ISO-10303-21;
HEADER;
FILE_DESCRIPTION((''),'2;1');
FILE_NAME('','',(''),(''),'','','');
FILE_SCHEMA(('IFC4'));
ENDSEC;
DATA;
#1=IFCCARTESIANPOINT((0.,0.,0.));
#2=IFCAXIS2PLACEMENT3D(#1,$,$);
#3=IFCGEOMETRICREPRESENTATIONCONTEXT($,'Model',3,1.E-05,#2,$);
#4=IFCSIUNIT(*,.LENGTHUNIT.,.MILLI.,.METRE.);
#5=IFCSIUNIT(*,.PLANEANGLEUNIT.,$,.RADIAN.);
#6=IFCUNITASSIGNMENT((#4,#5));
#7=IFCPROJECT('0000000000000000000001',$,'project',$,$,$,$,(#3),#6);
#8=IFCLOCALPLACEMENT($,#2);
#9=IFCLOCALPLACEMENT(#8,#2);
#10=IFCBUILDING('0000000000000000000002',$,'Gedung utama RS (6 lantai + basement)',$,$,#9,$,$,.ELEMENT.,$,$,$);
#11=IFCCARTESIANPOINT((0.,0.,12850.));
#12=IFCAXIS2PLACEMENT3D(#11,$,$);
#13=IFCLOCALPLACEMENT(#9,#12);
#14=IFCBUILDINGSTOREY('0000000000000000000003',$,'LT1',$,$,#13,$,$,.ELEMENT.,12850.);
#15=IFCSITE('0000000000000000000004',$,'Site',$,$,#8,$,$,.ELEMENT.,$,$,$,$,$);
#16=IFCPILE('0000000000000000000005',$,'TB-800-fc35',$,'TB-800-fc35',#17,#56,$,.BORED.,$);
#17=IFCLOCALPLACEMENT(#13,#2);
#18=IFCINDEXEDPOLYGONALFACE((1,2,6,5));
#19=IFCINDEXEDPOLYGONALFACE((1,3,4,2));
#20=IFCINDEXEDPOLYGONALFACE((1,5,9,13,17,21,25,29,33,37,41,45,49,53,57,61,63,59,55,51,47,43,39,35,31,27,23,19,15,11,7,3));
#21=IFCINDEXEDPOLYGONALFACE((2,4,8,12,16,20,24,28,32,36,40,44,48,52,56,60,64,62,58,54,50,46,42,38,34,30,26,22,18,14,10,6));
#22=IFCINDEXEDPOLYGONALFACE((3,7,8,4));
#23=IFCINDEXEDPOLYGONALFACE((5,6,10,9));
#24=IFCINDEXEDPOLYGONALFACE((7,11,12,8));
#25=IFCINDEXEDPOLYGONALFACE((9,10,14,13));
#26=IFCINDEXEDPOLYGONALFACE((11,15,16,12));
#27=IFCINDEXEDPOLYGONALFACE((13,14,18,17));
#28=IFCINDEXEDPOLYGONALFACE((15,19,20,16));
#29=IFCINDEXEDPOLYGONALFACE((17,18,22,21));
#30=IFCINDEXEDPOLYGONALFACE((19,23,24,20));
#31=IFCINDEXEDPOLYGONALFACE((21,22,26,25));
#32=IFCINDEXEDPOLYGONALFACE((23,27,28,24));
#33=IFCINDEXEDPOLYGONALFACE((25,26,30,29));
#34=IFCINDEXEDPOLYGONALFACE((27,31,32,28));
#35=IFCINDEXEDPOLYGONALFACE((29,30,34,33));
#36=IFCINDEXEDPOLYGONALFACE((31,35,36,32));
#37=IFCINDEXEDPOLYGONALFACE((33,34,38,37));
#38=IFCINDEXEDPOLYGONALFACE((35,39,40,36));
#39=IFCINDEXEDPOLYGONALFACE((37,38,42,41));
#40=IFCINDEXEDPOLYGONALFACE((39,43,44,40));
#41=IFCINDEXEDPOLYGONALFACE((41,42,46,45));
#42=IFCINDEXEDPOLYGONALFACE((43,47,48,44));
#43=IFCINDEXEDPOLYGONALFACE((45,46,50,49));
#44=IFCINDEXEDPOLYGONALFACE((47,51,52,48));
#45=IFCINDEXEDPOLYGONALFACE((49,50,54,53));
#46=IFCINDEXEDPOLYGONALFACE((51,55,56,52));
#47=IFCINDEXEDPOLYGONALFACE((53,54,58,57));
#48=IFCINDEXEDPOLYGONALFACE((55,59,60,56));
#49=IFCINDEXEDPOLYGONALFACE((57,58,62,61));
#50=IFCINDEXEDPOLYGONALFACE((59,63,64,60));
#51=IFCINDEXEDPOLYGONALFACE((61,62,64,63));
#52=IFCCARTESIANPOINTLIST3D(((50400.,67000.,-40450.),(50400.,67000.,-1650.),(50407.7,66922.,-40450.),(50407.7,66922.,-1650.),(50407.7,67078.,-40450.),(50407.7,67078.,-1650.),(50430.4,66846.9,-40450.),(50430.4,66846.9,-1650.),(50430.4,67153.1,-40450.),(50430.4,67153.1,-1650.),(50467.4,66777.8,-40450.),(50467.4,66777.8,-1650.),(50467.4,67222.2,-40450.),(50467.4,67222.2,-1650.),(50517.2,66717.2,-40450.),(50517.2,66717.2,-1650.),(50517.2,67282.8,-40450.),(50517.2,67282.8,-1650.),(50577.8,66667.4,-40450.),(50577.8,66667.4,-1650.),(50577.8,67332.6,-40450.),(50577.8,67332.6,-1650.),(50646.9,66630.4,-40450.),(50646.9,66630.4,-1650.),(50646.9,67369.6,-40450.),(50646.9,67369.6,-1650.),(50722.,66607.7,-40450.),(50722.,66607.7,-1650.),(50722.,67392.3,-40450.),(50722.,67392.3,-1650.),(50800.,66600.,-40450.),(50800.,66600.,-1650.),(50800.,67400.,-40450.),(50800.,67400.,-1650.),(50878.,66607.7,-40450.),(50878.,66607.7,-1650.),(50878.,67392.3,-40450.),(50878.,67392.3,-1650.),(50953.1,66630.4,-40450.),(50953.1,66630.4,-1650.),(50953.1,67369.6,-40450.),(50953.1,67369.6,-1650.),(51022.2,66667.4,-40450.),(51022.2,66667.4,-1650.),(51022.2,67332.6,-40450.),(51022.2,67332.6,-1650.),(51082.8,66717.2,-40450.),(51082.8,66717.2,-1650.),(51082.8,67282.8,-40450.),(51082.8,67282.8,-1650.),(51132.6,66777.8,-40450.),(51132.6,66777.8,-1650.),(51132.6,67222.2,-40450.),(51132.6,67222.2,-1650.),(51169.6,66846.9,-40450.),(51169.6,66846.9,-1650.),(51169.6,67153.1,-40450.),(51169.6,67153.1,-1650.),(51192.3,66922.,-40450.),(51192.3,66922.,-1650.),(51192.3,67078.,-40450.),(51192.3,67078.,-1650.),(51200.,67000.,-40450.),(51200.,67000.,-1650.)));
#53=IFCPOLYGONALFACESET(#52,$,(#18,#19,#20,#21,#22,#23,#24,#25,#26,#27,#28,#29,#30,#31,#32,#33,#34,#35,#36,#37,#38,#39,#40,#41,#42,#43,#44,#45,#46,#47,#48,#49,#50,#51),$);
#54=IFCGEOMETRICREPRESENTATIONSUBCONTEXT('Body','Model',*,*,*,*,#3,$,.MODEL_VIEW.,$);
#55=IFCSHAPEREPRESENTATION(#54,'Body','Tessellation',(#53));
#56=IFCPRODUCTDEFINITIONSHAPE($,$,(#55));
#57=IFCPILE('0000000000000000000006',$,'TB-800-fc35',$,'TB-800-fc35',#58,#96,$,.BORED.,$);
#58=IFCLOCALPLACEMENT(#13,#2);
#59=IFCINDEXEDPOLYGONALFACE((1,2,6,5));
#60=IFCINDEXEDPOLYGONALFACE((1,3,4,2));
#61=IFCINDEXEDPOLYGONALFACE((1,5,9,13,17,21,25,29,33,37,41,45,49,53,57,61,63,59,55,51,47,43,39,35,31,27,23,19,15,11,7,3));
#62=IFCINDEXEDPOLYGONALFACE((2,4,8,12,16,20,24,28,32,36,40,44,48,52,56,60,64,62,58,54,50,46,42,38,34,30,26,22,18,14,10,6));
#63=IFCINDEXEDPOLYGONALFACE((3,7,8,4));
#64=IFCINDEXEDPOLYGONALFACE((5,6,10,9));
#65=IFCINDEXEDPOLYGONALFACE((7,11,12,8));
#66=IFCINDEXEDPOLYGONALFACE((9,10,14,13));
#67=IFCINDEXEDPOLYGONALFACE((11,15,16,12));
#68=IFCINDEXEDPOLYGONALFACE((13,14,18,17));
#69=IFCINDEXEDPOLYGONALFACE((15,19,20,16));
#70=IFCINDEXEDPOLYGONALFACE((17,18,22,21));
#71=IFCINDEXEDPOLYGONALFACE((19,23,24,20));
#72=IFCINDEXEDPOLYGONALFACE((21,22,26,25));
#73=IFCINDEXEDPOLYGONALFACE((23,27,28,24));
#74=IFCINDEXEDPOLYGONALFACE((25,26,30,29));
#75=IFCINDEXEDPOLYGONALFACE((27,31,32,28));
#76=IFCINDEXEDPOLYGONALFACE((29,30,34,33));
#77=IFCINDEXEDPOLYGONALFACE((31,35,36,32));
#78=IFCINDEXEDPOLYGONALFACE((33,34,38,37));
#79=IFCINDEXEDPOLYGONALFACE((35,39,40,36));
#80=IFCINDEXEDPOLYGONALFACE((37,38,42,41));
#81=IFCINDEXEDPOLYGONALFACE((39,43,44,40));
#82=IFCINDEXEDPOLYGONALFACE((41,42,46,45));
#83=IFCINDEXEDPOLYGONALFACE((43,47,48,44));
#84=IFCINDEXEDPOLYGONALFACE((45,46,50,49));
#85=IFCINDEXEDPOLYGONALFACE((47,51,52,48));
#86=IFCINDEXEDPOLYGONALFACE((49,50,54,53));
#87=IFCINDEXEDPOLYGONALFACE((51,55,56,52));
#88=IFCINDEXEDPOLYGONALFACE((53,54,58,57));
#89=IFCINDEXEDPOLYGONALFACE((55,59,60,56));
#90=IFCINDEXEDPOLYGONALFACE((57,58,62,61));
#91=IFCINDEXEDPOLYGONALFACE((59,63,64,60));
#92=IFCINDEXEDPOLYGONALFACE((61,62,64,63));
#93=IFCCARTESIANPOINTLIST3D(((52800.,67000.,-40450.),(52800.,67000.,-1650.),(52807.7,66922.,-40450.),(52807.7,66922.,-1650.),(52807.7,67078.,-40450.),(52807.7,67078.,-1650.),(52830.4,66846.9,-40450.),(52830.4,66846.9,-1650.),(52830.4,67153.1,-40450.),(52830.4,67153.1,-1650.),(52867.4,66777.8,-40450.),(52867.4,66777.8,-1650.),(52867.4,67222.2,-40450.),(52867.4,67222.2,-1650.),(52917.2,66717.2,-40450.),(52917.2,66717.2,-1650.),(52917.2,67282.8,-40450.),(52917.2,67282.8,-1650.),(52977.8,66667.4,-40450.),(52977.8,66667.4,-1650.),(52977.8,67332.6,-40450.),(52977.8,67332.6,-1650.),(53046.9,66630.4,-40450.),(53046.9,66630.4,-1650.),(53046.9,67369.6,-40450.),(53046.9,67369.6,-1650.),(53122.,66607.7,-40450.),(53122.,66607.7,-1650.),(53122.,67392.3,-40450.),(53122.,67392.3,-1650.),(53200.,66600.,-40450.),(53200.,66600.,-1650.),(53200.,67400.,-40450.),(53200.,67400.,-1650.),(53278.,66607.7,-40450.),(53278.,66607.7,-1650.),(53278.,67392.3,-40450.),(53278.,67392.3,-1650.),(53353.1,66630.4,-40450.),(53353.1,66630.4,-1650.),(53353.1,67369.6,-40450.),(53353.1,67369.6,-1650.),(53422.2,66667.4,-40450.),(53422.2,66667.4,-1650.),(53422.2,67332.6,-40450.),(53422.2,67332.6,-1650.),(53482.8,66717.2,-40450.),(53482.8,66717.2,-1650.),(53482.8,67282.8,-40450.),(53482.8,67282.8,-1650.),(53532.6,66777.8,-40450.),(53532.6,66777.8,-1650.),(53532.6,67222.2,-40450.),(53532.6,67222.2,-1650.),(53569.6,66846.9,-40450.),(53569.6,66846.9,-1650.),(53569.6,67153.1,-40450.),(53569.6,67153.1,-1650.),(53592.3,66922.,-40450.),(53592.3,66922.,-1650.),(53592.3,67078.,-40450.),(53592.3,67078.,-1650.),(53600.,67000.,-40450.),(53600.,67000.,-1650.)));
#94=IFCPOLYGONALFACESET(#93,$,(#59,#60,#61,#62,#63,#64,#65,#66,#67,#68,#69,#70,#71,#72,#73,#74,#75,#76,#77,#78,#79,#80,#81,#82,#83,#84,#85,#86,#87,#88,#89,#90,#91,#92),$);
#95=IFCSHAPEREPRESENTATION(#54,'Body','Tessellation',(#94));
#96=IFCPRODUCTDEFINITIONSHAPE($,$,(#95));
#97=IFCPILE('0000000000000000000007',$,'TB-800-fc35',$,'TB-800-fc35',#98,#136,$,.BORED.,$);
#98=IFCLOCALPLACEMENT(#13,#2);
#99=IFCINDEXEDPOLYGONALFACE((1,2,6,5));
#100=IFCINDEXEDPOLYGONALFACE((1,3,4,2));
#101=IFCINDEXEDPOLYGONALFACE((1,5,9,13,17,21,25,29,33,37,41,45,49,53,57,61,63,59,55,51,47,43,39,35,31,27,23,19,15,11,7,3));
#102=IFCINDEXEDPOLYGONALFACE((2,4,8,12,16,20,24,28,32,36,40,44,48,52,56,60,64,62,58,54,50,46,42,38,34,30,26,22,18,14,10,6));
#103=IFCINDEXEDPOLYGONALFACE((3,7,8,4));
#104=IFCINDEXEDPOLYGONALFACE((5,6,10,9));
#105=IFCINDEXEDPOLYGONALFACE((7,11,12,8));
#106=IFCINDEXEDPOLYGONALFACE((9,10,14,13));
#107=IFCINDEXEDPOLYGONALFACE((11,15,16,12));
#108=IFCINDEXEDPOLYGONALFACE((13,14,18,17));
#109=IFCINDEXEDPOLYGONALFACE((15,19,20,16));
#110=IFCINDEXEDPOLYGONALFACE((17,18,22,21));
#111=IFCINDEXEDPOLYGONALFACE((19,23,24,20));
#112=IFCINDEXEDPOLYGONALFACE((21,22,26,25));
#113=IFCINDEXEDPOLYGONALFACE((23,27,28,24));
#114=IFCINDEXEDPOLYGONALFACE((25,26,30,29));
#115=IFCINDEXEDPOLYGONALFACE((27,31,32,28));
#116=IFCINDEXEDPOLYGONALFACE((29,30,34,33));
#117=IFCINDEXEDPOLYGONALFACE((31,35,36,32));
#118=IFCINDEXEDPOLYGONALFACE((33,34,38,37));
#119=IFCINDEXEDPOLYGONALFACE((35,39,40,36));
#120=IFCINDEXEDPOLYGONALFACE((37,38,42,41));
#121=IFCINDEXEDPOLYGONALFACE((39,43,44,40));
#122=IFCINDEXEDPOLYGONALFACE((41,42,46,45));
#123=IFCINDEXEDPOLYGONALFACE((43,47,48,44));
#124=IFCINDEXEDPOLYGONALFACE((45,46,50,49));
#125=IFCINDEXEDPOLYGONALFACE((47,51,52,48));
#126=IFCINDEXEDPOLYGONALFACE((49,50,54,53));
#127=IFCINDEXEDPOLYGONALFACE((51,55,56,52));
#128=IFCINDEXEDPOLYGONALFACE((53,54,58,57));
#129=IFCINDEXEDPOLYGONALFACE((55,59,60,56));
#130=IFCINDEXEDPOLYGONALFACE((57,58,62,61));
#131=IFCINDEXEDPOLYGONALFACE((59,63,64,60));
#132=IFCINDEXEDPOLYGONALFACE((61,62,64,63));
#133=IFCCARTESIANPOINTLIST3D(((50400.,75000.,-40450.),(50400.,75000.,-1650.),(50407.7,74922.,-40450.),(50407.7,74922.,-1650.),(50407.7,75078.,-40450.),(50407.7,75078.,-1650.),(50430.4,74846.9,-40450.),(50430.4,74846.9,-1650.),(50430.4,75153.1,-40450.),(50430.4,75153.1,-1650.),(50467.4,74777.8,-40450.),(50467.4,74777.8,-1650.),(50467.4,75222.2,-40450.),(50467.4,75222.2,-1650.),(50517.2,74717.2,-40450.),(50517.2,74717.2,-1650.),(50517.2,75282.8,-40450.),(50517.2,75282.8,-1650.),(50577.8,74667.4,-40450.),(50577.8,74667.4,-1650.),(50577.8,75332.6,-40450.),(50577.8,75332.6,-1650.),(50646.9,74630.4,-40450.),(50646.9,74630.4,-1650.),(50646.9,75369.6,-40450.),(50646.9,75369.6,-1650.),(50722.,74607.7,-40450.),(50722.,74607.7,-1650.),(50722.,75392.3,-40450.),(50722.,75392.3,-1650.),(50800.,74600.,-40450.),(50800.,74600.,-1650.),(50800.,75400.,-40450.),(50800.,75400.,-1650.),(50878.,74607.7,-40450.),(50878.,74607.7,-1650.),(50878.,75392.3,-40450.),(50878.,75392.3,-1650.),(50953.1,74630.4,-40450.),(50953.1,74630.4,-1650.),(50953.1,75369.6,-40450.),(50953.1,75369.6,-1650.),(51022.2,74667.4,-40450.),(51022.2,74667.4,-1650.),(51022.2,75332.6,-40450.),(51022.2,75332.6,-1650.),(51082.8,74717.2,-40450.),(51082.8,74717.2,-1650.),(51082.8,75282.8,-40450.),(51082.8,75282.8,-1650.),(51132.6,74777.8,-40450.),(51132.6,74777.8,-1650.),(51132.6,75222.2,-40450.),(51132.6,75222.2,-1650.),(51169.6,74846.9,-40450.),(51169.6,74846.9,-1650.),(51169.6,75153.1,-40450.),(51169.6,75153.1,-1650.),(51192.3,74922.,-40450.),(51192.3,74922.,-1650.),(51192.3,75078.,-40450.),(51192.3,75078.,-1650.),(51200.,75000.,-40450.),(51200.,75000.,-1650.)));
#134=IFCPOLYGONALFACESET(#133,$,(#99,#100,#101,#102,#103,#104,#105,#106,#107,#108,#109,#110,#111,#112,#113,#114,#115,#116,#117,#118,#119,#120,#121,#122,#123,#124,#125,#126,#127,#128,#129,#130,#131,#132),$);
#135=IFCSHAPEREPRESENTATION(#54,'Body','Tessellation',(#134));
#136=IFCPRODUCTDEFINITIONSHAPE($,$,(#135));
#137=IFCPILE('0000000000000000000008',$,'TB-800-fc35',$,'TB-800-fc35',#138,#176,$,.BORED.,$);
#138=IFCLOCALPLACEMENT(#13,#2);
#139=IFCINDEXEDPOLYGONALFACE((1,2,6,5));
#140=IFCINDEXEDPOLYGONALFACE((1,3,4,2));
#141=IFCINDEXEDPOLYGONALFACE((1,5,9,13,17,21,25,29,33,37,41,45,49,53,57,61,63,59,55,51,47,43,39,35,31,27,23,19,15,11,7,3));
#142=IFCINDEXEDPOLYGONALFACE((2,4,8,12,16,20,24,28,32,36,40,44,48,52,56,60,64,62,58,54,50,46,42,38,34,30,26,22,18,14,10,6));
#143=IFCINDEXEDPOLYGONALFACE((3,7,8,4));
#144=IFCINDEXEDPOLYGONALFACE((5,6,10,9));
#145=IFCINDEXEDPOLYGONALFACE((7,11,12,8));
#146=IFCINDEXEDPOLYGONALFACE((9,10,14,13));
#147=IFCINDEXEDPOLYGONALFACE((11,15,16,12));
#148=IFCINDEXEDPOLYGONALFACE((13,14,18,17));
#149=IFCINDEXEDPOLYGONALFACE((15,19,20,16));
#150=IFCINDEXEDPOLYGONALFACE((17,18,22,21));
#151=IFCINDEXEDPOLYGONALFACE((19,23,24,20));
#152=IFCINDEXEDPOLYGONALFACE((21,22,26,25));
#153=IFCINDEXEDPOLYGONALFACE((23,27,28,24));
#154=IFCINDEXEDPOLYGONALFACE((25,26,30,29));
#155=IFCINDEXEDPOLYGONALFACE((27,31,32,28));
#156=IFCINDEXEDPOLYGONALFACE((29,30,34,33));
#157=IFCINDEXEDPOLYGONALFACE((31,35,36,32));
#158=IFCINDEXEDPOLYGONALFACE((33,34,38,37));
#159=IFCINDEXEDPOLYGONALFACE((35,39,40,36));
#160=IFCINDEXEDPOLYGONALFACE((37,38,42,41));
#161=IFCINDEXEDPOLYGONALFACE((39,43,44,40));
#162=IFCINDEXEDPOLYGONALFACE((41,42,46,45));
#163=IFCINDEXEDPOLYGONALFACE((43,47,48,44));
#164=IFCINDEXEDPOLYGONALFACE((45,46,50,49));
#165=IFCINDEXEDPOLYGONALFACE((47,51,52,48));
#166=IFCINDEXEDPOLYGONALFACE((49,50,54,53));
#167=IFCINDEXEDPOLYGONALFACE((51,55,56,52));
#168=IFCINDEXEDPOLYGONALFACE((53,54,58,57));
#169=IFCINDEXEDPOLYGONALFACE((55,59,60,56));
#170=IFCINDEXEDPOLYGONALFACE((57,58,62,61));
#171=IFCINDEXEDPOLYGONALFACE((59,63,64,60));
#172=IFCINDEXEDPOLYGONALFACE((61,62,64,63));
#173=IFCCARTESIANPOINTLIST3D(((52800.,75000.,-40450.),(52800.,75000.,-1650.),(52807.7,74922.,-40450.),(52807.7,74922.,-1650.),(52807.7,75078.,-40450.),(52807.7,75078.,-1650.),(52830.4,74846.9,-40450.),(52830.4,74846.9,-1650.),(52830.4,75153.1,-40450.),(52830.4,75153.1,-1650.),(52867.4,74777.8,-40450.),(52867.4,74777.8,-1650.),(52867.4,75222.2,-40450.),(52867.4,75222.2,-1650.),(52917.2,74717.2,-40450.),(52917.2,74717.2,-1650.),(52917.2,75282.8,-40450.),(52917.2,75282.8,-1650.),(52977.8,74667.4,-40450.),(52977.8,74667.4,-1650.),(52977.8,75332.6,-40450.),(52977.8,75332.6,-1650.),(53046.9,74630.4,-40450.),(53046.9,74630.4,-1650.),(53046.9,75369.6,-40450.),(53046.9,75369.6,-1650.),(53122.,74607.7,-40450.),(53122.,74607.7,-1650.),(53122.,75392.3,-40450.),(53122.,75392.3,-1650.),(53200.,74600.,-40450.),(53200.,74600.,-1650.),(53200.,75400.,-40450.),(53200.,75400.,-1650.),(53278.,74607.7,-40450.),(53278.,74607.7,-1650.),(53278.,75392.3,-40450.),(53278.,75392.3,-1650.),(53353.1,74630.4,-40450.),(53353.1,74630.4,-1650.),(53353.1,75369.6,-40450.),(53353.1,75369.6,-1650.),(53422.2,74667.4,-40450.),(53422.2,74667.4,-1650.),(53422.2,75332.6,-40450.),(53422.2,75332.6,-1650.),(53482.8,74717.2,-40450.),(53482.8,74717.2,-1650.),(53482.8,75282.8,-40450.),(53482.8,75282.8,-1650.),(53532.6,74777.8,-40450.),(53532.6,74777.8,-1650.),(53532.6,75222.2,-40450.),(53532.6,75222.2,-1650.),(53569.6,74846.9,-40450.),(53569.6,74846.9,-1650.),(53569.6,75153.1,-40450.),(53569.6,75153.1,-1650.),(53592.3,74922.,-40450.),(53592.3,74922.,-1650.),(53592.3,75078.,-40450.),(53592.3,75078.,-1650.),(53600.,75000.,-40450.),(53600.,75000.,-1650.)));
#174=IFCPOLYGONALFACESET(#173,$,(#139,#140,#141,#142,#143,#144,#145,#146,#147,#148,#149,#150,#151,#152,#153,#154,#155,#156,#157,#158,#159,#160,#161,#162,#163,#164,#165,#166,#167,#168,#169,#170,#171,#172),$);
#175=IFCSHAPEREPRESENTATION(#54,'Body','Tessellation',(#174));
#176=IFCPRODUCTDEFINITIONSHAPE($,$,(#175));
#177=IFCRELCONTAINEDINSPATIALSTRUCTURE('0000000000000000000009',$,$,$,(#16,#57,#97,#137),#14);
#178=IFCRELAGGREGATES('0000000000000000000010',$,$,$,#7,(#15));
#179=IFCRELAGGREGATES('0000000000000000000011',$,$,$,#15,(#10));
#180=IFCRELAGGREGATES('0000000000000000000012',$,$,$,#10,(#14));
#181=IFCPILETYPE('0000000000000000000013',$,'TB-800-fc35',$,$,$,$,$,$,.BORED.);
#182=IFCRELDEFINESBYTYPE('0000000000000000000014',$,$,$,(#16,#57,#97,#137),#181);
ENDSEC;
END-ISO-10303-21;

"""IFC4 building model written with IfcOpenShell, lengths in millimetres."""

from ifc_helpers import new_model, si_unit, frame, origin, origin_2d, place, context, subcontext, project, spatial, circle, extrude, material_profile, profile_set, profile_usage, type_object, element, save


model = new_model("IFC4")

# Units and contexts
model_context = context("Model", 3, precision=1e-05, world=origin())
body_context = subcontext(model_context, "Body", "Model", "MODEL_VIEW")
ifc_project = project(units=[si_unit("LENGTHUNIT", "METRE", prefix="MILLI"), si_unit("PLANEANGLEUNIT", "RADIAN")], contexts=[model_context])

# Site, building, storey
site_placement = place(None, origin())
site = spatial("IfcSite", under=ifc_project, at=site_placement, Name="Site", CompositionType="ELEMENT")
building_placement = place(site_placement, origin())
building = spatial("IfcBuilding", under=site, at=building_placement, Name="Gedung utama RS (6 lantai + basement)", CompositionType="ELEMENT")
storey_placement = place(building_placement, frame((0.0, 0.0, 12850.0)))
storey = spatial("IfcBuildingStorey", under=building, at=storey_placement, Name="LT1", CompositionType="ELEMENT", Elevation=12850.0)

# Piles
ifc_material_profile = material_profile(None, circle(Radius=400.0, at=origin_2d()), Name="TB-800-fc35")
ifc_profile_set = profile_set([ifc_material_profile], Name="TB-800-fc35")
ifc_profile_usage = profile_usage(ifc_profile_set, cardinal=5)
pile_type = type_object("IfcPileType", Name="TB-800-fc35", PredefinedType="BORED")
for number, where, z_axis, x_axis, name in (
    (1, (50800.0, 67000.0, -40450.0), (0.0, 0.0, 1.0), (1.0, 0.0, 0.0), "TB-800-fc35"),
    (2, (53200.0, 67000.0, -40450.0), (0.0, 0.0, 1.0), (1.0, 0.0, 0.0), "TB-800-fc35"),
    (3, (50800.0, 75000.0, -40450.0), (0.0, 0.0, 1.0), (1.0, 0.0, 0.0), "TB-800-fc35"),
    (4, (53200.0, 75000.0, -40450.0), (0.0, 0.0, 1.0), (1.0, 0.0, 0.0), "TB-800-fc35"),
):
    element("IfcPile", number, at=place(storey_placement, frame(where, z_axis=z_axis, x_axis=x_axis)), inside=storey, type_object=pile_type, material=ifc_profile_usage, Name=name, ObjectType="TB-800-fc35", PredefinedType="BORED", context=body_context, shape_type="SweptSolid", body=[
        extrude(circle(Radius=400.0, at=origin_2d()), origin(), (0.0, 0.0, 1.0), 38800.0),
    ])

save(model, "model.ifc")
